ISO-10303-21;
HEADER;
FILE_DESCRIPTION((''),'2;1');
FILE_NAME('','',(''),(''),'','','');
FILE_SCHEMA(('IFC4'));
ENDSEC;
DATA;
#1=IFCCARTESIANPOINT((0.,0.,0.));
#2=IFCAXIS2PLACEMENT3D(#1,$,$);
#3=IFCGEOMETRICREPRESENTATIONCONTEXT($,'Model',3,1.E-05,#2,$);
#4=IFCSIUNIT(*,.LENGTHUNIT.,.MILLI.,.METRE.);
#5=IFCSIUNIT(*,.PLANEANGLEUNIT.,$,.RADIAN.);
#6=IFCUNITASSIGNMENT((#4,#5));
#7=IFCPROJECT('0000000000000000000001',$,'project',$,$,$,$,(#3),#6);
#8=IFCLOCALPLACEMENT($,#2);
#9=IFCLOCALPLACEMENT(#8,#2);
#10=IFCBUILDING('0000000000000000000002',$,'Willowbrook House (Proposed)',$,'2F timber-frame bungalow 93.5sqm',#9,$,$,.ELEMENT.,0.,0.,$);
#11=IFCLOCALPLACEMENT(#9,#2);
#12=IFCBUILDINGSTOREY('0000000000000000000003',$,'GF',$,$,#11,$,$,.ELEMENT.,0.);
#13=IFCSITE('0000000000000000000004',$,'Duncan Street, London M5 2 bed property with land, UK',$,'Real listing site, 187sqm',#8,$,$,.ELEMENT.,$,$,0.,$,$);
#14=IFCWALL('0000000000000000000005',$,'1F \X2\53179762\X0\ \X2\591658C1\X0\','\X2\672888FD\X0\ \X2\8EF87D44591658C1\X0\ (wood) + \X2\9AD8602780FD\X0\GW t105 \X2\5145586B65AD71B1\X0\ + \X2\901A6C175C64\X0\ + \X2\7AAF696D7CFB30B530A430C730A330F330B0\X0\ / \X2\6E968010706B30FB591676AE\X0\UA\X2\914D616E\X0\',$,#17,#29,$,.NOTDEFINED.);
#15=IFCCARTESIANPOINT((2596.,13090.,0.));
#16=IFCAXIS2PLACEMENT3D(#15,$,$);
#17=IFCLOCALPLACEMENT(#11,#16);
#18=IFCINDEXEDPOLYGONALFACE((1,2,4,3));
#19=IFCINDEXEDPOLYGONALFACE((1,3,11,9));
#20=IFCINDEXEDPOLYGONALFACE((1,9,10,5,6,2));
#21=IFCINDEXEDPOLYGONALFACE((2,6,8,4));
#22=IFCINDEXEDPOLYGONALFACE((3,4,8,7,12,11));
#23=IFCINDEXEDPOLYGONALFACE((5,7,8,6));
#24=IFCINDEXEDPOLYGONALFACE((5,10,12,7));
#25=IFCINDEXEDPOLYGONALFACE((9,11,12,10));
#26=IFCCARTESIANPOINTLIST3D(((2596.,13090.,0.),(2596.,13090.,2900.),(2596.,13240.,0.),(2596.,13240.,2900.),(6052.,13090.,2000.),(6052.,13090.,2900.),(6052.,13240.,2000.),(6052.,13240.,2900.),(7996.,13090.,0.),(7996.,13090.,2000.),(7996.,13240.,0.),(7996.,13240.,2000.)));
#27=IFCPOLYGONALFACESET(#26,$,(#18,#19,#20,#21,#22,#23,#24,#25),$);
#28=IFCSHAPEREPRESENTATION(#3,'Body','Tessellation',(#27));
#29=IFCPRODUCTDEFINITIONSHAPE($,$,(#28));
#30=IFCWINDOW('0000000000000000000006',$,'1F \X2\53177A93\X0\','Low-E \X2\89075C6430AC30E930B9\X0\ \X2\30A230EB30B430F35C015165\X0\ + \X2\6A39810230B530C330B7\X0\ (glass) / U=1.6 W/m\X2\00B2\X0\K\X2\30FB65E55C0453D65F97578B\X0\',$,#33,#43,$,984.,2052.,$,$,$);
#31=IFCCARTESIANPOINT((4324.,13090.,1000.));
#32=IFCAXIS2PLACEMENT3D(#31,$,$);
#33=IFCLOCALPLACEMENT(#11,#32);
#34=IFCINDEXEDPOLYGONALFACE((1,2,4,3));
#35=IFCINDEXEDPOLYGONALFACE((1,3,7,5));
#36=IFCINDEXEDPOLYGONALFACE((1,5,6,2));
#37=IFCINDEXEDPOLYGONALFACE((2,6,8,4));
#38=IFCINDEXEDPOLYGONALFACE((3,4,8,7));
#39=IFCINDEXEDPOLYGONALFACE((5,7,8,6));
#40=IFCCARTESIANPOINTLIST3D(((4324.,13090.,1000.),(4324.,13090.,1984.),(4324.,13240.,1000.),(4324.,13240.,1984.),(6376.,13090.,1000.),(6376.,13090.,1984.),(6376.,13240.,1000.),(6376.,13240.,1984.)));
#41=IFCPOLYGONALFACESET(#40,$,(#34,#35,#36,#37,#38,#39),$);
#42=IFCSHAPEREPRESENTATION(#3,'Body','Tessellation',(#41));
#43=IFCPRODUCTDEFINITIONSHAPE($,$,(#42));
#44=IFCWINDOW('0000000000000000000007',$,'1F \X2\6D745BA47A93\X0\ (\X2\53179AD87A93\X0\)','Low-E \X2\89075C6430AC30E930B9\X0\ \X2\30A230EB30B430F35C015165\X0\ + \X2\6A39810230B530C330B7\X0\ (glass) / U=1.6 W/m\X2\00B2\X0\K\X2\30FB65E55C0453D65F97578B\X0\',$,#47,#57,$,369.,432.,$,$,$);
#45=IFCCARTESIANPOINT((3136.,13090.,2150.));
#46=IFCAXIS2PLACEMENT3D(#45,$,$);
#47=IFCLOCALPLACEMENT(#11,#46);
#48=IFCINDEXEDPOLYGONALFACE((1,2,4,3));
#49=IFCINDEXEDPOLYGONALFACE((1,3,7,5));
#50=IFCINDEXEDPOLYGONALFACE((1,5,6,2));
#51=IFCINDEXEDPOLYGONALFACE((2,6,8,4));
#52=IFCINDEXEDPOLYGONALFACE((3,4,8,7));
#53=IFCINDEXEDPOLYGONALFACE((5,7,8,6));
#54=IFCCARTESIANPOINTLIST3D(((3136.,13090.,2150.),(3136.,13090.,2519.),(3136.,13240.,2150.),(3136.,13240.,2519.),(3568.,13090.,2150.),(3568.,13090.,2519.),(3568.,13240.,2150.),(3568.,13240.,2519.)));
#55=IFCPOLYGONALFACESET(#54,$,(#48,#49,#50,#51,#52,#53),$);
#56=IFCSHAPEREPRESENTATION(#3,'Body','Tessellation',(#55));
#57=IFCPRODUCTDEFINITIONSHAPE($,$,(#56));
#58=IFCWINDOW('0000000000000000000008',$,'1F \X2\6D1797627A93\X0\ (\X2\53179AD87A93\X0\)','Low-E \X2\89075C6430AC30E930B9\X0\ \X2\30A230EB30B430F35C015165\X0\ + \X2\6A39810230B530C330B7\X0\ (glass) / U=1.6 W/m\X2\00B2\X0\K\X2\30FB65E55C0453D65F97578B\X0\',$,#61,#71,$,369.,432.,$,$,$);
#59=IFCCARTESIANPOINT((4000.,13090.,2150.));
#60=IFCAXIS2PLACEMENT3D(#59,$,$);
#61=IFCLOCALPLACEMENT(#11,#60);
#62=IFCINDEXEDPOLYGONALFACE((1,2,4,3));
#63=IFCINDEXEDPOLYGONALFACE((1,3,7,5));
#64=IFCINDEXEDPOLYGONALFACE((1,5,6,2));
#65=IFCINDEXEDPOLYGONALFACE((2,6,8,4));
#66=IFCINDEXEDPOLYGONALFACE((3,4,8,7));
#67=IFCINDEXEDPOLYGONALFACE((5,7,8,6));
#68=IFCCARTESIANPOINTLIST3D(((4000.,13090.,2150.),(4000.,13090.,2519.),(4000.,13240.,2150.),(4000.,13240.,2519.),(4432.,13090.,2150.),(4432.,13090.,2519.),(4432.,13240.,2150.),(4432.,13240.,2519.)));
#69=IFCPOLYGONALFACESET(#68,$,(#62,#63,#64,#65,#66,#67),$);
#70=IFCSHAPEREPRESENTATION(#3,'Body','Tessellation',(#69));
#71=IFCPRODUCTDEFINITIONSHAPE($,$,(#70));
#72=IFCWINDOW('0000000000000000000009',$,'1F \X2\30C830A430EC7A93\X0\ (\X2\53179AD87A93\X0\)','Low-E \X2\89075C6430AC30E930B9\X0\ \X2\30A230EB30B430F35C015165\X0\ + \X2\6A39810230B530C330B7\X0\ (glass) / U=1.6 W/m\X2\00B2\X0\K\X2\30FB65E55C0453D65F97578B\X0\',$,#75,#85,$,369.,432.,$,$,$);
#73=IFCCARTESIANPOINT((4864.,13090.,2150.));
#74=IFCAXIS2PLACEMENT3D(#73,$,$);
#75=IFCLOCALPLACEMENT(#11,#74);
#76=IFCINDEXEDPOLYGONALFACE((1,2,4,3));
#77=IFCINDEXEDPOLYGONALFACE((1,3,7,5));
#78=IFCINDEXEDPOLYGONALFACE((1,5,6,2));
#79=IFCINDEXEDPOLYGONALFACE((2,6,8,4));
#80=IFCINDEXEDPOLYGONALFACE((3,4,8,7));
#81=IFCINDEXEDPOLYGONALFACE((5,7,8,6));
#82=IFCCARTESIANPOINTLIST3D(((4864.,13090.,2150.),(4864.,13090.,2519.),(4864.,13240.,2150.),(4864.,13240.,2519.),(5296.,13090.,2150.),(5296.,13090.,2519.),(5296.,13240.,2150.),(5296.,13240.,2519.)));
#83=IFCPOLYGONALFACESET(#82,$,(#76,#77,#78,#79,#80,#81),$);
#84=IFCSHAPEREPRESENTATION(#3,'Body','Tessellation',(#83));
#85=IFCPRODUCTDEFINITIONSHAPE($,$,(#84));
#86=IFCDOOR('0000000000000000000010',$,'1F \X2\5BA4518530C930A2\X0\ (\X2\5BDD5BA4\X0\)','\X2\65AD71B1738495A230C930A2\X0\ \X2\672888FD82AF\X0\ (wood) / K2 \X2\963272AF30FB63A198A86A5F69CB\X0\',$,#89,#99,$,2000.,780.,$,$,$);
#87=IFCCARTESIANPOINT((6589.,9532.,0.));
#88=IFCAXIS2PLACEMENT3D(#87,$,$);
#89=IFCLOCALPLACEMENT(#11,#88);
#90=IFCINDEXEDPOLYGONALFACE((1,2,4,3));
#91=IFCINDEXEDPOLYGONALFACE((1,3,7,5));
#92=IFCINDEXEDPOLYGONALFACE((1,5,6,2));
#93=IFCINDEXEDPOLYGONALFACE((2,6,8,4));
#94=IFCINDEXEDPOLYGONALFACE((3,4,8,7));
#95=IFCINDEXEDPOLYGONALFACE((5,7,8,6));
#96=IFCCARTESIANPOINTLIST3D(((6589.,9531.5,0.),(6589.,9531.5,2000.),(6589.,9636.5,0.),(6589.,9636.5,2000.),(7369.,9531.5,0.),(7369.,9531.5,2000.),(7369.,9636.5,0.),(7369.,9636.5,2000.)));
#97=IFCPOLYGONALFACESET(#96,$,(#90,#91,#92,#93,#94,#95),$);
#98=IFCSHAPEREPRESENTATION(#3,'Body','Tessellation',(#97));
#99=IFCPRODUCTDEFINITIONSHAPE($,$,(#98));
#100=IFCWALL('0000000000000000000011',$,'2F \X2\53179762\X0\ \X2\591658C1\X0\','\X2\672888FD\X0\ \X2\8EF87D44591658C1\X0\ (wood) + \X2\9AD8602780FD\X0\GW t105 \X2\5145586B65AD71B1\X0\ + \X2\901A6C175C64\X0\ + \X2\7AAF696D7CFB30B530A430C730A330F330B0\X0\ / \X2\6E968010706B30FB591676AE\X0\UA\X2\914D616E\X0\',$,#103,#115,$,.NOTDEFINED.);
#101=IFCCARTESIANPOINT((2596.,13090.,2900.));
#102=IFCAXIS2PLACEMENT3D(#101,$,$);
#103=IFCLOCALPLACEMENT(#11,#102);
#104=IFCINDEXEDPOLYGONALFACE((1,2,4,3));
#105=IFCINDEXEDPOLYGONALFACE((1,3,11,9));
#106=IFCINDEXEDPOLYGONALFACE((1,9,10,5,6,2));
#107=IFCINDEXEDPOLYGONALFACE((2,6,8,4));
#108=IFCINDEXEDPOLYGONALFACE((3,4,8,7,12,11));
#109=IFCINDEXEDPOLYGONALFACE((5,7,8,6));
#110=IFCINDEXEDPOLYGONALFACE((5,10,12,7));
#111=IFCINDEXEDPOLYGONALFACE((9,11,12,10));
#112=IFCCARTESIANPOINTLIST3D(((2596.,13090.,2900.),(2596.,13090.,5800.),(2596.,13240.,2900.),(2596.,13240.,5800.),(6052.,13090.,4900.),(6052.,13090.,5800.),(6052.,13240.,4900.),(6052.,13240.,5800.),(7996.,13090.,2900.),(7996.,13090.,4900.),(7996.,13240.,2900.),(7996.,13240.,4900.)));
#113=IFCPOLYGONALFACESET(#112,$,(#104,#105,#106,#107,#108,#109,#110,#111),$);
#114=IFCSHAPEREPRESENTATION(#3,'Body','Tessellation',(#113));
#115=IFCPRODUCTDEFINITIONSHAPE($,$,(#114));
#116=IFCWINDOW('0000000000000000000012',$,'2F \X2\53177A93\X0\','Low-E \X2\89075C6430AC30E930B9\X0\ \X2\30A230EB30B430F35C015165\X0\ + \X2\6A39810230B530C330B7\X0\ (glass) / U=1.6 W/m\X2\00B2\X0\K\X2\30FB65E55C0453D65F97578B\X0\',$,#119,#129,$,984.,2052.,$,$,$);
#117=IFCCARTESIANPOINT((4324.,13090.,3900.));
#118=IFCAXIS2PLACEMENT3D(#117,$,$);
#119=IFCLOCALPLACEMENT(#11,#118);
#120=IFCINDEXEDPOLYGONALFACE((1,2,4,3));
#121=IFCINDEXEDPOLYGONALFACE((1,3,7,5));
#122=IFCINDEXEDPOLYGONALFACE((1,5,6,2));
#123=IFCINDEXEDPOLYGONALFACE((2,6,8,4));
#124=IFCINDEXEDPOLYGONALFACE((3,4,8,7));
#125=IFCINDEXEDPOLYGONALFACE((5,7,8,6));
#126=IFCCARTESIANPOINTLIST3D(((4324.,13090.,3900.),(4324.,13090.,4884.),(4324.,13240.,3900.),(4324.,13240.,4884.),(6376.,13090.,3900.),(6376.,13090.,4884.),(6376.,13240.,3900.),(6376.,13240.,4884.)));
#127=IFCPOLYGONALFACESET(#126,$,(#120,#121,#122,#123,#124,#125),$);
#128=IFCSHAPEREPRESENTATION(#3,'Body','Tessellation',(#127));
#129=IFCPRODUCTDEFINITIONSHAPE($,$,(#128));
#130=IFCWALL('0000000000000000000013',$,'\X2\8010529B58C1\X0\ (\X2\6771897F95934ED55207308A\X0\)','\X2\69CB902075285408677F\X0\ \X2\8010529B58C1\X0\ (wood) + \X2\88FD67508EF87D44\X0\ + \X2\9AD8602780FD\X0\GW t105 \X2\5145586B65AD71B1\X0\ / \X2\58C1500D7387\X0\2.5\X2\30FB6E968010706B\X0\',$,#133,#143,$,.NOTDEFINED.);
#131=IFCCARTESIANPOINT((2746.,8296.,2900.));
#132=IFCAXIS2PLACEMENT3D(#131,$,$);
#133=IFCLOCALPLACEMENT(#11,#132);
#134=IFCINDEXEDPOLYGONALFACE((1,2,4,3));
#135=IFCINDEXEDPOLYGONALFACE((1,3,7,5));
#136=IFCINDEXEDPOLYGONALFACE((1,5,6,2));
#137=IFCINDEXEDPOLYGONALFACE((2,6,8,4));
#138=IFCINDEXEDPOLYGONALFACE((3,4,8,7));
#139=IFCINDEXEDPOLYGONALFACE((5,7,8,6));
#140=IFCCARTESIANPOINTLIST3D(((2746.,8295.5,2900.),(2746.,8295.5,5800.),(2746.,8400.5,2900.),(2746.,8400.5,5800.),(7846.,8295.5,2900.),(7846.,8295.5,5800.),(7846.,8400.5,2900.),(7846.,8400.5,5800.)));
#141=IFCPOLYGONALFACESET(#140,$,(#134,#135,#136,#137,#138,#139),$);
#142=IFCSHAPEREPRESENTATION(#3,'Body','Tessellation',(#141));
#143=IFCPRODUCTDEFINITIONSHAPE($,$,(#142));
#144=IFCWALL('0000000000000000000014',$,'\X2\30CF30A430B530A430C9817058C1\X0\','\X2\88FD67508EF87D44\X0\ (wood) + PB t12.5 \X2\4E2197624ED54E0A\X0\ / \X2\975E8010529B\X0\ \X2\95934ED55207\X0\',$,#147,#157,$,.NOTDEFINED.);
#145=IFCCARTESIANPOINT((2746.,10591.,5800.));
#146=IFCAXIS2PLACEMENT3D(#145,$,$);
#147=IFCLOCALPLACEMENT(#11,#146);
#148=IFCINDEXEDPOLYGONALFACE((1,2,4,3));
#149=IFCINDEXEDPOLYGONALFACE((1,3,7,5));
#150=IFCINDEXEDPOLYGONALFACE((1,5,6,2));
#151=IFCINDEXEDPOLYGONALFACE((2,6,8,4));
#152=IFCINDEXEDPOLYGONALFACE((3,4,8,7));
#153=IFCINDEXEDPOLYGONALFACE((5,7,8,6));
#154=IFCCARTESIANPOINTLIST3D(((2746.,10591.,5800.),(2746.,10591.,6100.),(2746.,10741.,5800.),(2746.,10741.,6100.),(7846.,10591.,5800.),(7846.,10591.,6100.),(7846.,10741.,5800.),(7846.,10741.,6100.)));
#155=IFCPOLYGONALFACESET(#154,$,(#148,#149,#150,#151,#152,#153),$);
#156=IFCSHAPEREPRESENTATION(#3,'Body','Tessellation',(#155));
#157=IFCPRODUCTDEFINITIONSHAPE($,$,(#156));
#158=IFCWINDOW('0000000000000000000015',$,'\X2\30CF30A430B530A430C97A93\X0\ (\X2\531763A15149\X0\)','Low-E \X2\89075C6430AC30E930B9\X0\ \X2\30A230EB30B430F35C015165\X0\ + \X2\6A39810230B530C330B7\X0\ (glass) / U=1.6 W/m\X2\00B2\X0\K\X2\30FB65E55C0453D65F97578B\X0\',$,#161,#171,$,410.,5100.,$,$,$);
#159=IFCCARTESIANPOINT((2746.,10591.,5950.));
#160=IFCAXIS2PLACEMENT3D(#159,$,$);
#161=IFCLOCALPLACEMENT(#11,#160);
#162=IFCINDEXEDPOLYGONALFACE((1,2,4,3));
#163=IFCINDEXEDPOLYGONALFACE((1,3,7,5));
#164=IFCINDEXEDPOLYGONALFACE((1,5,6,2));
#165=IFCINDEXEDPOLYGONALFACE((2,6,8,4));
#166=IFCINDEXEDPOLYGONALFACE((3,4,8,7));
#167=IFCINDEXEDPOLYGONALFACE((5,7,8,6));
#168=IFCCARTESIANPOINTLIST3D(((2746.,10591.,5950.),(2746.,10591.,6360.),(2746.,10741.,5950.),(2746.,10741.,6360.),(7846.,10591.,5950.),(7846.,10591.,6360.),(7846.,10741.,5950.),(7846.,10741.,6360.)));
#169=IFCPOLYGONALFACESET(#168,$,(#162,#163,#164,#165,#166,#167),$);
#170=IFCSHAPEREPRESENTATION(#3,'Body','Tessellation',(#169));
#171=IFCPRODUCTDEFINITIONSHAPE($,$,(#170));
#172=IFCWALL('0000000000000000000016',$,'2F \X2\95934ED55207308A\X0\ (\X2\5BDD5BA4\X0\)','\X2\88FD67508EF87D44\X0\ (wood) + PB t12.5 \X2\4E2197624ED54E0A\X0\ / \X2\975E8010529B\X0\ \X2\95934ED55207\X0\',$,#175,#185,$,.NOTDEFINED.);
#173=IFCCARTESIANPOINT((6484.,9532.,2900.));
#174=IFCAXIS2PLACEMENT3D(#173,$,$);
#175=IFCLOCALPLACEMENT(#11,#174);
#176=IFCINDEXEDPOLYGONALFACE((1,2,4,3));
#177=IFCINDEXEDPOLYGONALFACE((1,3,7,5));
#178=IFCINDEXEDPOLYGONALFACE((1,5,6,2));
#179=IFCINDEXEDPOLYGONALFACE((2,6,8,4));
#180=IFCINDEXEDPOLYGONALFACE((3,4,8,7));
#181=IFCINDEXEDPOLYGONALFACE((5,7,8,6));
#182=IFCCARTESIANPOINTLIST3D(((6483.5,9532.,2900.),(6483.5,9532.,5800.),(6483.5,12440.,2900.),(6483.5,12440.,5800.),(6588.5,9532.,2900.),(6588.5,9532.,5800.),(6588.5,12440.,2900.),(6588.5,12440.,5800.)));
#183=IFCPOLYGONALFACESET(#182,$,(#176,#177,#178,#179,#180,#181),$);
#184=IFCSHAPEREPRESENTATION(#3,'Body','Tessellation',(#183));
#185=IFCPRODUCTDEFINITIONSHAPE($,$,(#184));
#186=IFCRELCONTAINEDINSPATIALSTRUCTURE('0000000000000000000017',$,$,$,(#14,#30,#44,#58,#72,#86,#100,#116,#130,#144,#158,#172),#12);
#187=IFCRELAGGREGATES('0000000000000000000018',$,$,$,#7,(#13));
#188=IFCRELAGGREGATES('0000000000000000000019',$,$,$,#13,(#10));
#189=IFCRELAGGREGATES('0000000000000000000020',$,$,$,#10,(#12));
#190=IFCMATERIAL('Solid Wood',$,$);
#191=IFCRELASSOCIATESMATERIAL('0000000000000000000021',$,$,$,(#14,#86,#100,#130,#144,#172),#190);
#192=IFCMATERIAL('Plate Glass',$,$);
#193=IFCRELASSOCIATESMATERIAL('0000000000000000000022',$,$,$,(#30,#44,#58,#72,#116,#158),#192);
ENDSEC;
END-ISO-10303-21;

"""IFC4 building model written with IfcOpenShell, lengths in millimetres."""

from ifc_helpers import new_model, si_unit, frame, frame_2d, origin, place, context, project, spatial, rectangle, extrude, material, element, fill, save


model = new_model("IFC4")

# Units and contexts
model_context = context("Model", 3, precision=1e-05, world=origin())
ifc_project = project(units=[si_unit("LENGTHUNIT", "METRE", prefix="MILLI"), si_unit("PLANEANGLEUNIT", "RADIAN")], contexts=[model_context])

# Site, building, storey
site_placement = place(None, origin())
site = spatial("IfcSite", under=ifc_project, at=site_placement, Name="Duncan Street, London M5 2 bed property with land, UK", ObjectType="Real listing site, 187sqm", CompositionType="ELEMENT", RefElevation=0.0)
building_placement = place(site_placement, origin())
building = spatial("IfcBuilding", under=site, at=building_placement, Name="Willowbrook House (Proposed)", ObjectType="2F timber-frame bungalow 93.5sqm", CompositionType="ELEMENT", ElevationOfRefHeight=0.0, ElevationOfTerrain=0.0)
storey_placement = place(building_placement, origin())
storey = spatial("IfcBuildingStorey", under=building, at=storey_placement, Name="GF", CompositionType="ELEMENT", Elevation=0.0)

# Wall, openings, windows
ifc_material_1 = material(Name="Solid Wood")
wall_1_placement = place(storey_placement, frame((2596.0, 13090.0, 0.0)))
wall_1 = element("IfcWall", 1, at=wall_1_placement, inside=storey, material=ifc_material_1, Name="1F 北面 外壁", Description="木製 軸組外壁 (wood) + 高性能GW t105 充填断熱 + 通気層 + 窯業系サイディング / 準耐火・外皮UA配慮", PredefinedType="NOTDEFINED", context=model_context, shape_type="SweptSolid", body=[
    extrude(rectangle(XDim=5400.0, YDim=150.0, at=frame_2d((2700.0, 75.0))), frame((2596.0, 13090.0, 0.0)), (0.0, 0.0, 1.0), 2900.0),
])
opening_1_placement = place(storey_placement, frame((4324.0, 13090.0, 1000.0)))
opening_1 = element("IfcOpeningElement", 2, at=opening_1_placement, cuts=wall_1, PredefinedType="NOTDEFINED", context=model_context, shape_type="SweptSolid", body=[
    extrude(rectangle(XDim=2052.0, YDim=150.0, at=frame_2d((1026.0, 75.0))), frame((4324.0, 13090.0, 1000.0)), (0.0, 0.0, 1.0), 984.0),
])
opening_2_placement = place(storey_placement, frame((3136.0, 13090.0, 2150.0)))
opening_2 = element("IfcOpeningElement", 3, at=opening_2_placement, cuts=wall_1, PredefinedType="NOTDEFINED", context=model_context, shape_type="SweptSolid", body=[
    extrude(rectangle(XDim=432.0, YDim=150.0, at=frame_2d((216.0, 75.0))), frame((3136.0, 13090.0, 2150.0)), (0.0, 0.0, 1.0), 369.0),
])
opening_3_placement = place(storey_placement, frame((4000.0, 13090.0, 2150.0)))
opening_3 = element("IfcOpeningElement", 4, at=opening_3_placement, cuts=wall_1, PredefinedType="NOTDEFINED", context=model_context, shape_type="SweptSolid", body=[
    extrude(rectangle(XDim=432.0, YDim=150.0, at=frame_2d((216.0, 75.0))), frame((4000.0, 13090.0, 2150.0)), (0.0, 0.0, 1.0), 369.0),
])
opening_4_placement = place(storey_placement, frame((4864.0, 13090.0, 2150.0)))
opening_4 = element("IfcOpeningElement", 5, at=opening_4_placement, cuts=wall_1, PredefinedType="NOTDEFINED", context=model_context, shape_type="SweptSolid", body=[
    extrude(rectangle(XDim=432.0, YDim=150.0, at=frame_2d((216.0, 75.0))), frame((4864.0, 13090.0, 2150.0)), (0.0, 0.0, 1.0), 369.0),
])
ifc_material_2 = material(Name="Plate Glass")
window_1_placement = place(storey_placement, frame((4324.0, 13090.0, 1000.0)))
window_1 = element("IfcWindow", 6, at=window_1_placement, inside=storey, material=ifc_material_2, Name="1F 北窓", Description="Low-E 複層ガラス アルゴン封入 + 樹脂サッシ (glass) / U=1.6 W/m²K・日射取得型", OverallHeight=984.0, OverallWidth=2052.0, context=model_context, shape_type="SweptSolid", body=[
    extrude(rectangle(XDim=2052.0, YDim=150.0, at=frame_2d((1026.0, 75.0))), frame((4324.0, 13090.0, 1000.0)), (0.0, 0.0, 1.0), 984.0),
])
fill(opening_1, window_1)
window_2_placement = place(storey_placement, frame((3136.0, 13090.0, 2150.0)))
window_2 = element("IfcWindow", 7, at=window_2_placement, inside=storey, material=ifc_material_2, Name="1F 浴室窓 (北高窓)", Description="Low-E 複層ガラス アルゴン封入 + 樹脂サッシ (glass) / U=1.6 W/m²K・日射取得型", OverallHeight=369.0, OverallWidth=432.0, context=model_context, shape_type="SweptSolid", body=[
    extrude(rectangle(XDim=432.0, YDim=150.0, at=frame_2d((216.0, 75.0))), frame((3136.0, 13090.0, 2150.0)), (0.0, 0.0, 1.0), 369.0),
])
fill(opening_2, window_2)
window_3_placement = place(storey_placement, frame((4000.0, 13090.0, 2150.0)))
window_3 = element("IfcWindow", 8, at=window_3_placement, inside=storey, material=ifc_material_2, Name="1F 洗面窓 (北高窓)", Description="Low-E 複層ガラス アルゴン封入 + 樹脂サッシ (glass) / U=1.6 W/m²K・日射取得型", OverallHeight=369.0, OverallWidth=432.0, context=model_context, shape_type="SweptSolid", body=[
    extrude(rectangle(XDim=432.0, YDim=150.0, at=frame_2d((216.0, 75.0))), frame((4000.0, 13090.0, 2150.0)), (0.0, 0.0, 1.0), 369.0),
])
fill(opening_3, window_3)
window_4_placement = place(storey_placement, frame((4864.0, 13090.0, 2150.0)))
window_4 = element("IfcWindow", 9, at=window_4_placement, inside=storey, material=ifc_material_2, Name="1F トイレ窓 (北高窓)", Description="Low-E 複層ガラス アルゴン封入 + 樹脂サッシ (glass) / U=1.6 W/m²K・日射取得型", OverallHeight=369.0, OverallWidth=432.0, context=model_context, shape_type="SweptSolid", body=[
    extrude(rectangle(XDim=432.0, YDim=150.0, at=frame_2d((216.0, 75.0))), frame((4864.0, 13090.0, 2150.0)), (0.0, 0.0, 1.0), 369.0),
])
fill(opening_4, window_4)

# Door
door_1_placement = place(storey_placement, frame((6589.0, 9532.0, 0.0)))
element("IfcDoor", 10, at=door_1_placement, inside=storey, material=ifc_material_1, Name="1F 室内ドア (寝室)", Description="断熱玄関ドア 木製芯 (wood) / K2 防犯・採風機構", OverallHeight=2000.0, OverallWidth=780.0, context=model_context, shape_type="SweptSolid", body=[
    extrude(rectangle(XDim=780.0, YDim=105.0, at=frame_2d((390.0, 52.0))), frame((6589.0, 9532.0, 0.0)), (0.0, 0.0, 1.0), 2000.0),
])

# Wall, opening, window
wall_2_placement = place(storey_placement, frame((2596.0, 13090.0, 2900.0)))
wall_2 = element("IfcWall", 11, at=wall_2_placement, inside=storey, material=ifc_material_1, Name="2F 北面 外壁", Description="木製 軸組外壁 (wood) + 高性能GW t105 充填断熱 + 通気層 + 窯業系サイディング / 準耐火・外皮UA配慮", PredefinedType="NOTDEFINED", context=model_context, shape_type="SweptSolid", body=[
    extrude(rectangle(XDim=5400.0, YDim=150.0, at=frame_2d((2700.0, 75.0))), frame((2596.0, 13090.0, 2900.0)), (0.0, 0.0, 1.0), 2900.0),
])
opening_5_placement = place(storey_placement, frame((4324.0, 13090.0, 3900.0)))
opening_5 = element("IfcOpeningElement", 12, at=opening_5_placement, cuts=wall_2, PredefinedType="NOTDEFINED", context=model_context, shape_type="SweptSolid", body=[
    extrude(rectangle(XDim=2052.0, YDim=150.0, at=frame_2d((1026.0, 75.0))), frame((4324.0, 13090.0, 3900.0)), (0.0, 0.0, 1.0), 984.0),
])
window_5_placement = place(storey_placement, frame((4324.0, 13090.0, 3900.0)))
window_5 = element("IfcWindow", 13, at=window_5_placement, inside=storey, material=ifc_material_2, Name="2F 北窓", Description="Low-E 複層ガラス アルゴン封入 + 樹脂サッシ (glass) / U=1.6 W/m²K・日射取得型", OverallHeight=984.0, OverallWidth=2052.0, context=model_context, shape_type="SweptSolid", body=[
    extrude(rectangle(XDim=2052.0, YDim=150.0, at=frame_2d((1026.0, 75.0))), frame((4324.0, 13090.0, 3900.0)), (0.0, 0.0, 1.0), 984.0),
])
fill(opening_5, window_5)

# Wall
wall_3_placement = place(storey_placement, frame((2746.0, 8296.0, 2900.0)))
element("IfcWall", 14, at=wall_3_placement, inside=storey, material=ifc_material_1, Name="耐力壁 (東西間仕切り)", Description="構造用合板 耐力壁 (wood) + 製材軸組 + 高性能GW t105 充填断熱 / 壁倍率2.5・準耐火", PredefinedType="NOTDEFINED", context=model_context, shape_type="SweptSolid", body=[
    extrude(rectangle(XDim=5100.0, YDim=105.0, at=frame_2d((2550.0, 52.0))), frame((2746.0, 8296.0, 2900.0)), (0.0, 0.0, 1.0), 2900.0),
])

# Wall, opening, window
wall_4_placement = place(storey_placement, frame((2746.0, 10591.0, 5800.0)))
wall_4 = element("IfcWall", 15, at=wall_4_placement, inside=storey, material=ifc_material_1, Name="ハイサイド腰壁", Description="製材軸組 (wood) + PB t12.5 両面仕上 / 非耐力 間仕切", PredefinedType="NOTDEFINED", context=model_context, shape_type="SweptSolid", body=[
    extrude(rectangle(XDim=5100.0, YDim=150.0, at=frame_2d((2550.0, 75.0))), frame((2746.0, 10591.0, 5800.0)), (0.0, 0.0, 1.0), 700.0),
])
opening_6_placement = place(storey_placement, frame((2746.0, 10591.0, 5950.0)))
opening_6 = element("IfcOpeningElement", 16, at=opening_6_placement, cuts=wall_4, PredefinedType="NOTDEFINED", context=model_context, shape_type="SweptSolid", body=[
    extrude(rectangle(XDim=5100.0, YDim=150.0, at=frame_2d((2550.0, 75.0))), frame((2746.0, 10591.0, 5950.0)), (0.0, 0.0, 1.0), 410.0),
])
window_6_placement = place(storey_placement, frame((2746.0, 10591.0, 5950.0)))
window_6 = element("IfcWindow", 17, at=window_6_placement, inside=storey, material=ifc_material_2, Name="ハイサイド窓 (北採光)", Description="Low-E 複層ガラス アルゴン封入 + 樹脂サッシ (glass) / U=1.6 W/m²K・日射取得型", OverallHeight=410.0, OverallWidth=5100.0, context=model_context, shape_type="SweptSolid", body=[
    extrude(rectangle(XDim=5100.0, YDim=150.0, at=frame_2d((2550.0, 75.0))), frame((2746.0, 10591.0, 5950.0)), (0.0, 0.0, 1.0), 410.0),
])
fill(opening_6, window_6)

# Wall
wall_5_placement = place(storey_placement, frame((6484.0, 9532.0, 2900.0)))
element("IfcWall", 18, at=wall_5_placement, inside=storey, material=ifc_material_1, Name="2F 間仕切り (寝室)", Description="製材軸組 (wood) + PB t12.5 両面仕上 / 非耐力 間仕切", PredefinedType="NOTDEFINED", context=model_context, shape_type="SweptSolid", body=[
    extrude(rectangle(XDim=105.0, YDim=2908.0, at=frame_2d((52.0, 1454.0))), frame((6484.0, 9532.0, 2900.0)), (0.0, 0.0, 1.0), 2900.0),
])

save(model, "model.ifc")
